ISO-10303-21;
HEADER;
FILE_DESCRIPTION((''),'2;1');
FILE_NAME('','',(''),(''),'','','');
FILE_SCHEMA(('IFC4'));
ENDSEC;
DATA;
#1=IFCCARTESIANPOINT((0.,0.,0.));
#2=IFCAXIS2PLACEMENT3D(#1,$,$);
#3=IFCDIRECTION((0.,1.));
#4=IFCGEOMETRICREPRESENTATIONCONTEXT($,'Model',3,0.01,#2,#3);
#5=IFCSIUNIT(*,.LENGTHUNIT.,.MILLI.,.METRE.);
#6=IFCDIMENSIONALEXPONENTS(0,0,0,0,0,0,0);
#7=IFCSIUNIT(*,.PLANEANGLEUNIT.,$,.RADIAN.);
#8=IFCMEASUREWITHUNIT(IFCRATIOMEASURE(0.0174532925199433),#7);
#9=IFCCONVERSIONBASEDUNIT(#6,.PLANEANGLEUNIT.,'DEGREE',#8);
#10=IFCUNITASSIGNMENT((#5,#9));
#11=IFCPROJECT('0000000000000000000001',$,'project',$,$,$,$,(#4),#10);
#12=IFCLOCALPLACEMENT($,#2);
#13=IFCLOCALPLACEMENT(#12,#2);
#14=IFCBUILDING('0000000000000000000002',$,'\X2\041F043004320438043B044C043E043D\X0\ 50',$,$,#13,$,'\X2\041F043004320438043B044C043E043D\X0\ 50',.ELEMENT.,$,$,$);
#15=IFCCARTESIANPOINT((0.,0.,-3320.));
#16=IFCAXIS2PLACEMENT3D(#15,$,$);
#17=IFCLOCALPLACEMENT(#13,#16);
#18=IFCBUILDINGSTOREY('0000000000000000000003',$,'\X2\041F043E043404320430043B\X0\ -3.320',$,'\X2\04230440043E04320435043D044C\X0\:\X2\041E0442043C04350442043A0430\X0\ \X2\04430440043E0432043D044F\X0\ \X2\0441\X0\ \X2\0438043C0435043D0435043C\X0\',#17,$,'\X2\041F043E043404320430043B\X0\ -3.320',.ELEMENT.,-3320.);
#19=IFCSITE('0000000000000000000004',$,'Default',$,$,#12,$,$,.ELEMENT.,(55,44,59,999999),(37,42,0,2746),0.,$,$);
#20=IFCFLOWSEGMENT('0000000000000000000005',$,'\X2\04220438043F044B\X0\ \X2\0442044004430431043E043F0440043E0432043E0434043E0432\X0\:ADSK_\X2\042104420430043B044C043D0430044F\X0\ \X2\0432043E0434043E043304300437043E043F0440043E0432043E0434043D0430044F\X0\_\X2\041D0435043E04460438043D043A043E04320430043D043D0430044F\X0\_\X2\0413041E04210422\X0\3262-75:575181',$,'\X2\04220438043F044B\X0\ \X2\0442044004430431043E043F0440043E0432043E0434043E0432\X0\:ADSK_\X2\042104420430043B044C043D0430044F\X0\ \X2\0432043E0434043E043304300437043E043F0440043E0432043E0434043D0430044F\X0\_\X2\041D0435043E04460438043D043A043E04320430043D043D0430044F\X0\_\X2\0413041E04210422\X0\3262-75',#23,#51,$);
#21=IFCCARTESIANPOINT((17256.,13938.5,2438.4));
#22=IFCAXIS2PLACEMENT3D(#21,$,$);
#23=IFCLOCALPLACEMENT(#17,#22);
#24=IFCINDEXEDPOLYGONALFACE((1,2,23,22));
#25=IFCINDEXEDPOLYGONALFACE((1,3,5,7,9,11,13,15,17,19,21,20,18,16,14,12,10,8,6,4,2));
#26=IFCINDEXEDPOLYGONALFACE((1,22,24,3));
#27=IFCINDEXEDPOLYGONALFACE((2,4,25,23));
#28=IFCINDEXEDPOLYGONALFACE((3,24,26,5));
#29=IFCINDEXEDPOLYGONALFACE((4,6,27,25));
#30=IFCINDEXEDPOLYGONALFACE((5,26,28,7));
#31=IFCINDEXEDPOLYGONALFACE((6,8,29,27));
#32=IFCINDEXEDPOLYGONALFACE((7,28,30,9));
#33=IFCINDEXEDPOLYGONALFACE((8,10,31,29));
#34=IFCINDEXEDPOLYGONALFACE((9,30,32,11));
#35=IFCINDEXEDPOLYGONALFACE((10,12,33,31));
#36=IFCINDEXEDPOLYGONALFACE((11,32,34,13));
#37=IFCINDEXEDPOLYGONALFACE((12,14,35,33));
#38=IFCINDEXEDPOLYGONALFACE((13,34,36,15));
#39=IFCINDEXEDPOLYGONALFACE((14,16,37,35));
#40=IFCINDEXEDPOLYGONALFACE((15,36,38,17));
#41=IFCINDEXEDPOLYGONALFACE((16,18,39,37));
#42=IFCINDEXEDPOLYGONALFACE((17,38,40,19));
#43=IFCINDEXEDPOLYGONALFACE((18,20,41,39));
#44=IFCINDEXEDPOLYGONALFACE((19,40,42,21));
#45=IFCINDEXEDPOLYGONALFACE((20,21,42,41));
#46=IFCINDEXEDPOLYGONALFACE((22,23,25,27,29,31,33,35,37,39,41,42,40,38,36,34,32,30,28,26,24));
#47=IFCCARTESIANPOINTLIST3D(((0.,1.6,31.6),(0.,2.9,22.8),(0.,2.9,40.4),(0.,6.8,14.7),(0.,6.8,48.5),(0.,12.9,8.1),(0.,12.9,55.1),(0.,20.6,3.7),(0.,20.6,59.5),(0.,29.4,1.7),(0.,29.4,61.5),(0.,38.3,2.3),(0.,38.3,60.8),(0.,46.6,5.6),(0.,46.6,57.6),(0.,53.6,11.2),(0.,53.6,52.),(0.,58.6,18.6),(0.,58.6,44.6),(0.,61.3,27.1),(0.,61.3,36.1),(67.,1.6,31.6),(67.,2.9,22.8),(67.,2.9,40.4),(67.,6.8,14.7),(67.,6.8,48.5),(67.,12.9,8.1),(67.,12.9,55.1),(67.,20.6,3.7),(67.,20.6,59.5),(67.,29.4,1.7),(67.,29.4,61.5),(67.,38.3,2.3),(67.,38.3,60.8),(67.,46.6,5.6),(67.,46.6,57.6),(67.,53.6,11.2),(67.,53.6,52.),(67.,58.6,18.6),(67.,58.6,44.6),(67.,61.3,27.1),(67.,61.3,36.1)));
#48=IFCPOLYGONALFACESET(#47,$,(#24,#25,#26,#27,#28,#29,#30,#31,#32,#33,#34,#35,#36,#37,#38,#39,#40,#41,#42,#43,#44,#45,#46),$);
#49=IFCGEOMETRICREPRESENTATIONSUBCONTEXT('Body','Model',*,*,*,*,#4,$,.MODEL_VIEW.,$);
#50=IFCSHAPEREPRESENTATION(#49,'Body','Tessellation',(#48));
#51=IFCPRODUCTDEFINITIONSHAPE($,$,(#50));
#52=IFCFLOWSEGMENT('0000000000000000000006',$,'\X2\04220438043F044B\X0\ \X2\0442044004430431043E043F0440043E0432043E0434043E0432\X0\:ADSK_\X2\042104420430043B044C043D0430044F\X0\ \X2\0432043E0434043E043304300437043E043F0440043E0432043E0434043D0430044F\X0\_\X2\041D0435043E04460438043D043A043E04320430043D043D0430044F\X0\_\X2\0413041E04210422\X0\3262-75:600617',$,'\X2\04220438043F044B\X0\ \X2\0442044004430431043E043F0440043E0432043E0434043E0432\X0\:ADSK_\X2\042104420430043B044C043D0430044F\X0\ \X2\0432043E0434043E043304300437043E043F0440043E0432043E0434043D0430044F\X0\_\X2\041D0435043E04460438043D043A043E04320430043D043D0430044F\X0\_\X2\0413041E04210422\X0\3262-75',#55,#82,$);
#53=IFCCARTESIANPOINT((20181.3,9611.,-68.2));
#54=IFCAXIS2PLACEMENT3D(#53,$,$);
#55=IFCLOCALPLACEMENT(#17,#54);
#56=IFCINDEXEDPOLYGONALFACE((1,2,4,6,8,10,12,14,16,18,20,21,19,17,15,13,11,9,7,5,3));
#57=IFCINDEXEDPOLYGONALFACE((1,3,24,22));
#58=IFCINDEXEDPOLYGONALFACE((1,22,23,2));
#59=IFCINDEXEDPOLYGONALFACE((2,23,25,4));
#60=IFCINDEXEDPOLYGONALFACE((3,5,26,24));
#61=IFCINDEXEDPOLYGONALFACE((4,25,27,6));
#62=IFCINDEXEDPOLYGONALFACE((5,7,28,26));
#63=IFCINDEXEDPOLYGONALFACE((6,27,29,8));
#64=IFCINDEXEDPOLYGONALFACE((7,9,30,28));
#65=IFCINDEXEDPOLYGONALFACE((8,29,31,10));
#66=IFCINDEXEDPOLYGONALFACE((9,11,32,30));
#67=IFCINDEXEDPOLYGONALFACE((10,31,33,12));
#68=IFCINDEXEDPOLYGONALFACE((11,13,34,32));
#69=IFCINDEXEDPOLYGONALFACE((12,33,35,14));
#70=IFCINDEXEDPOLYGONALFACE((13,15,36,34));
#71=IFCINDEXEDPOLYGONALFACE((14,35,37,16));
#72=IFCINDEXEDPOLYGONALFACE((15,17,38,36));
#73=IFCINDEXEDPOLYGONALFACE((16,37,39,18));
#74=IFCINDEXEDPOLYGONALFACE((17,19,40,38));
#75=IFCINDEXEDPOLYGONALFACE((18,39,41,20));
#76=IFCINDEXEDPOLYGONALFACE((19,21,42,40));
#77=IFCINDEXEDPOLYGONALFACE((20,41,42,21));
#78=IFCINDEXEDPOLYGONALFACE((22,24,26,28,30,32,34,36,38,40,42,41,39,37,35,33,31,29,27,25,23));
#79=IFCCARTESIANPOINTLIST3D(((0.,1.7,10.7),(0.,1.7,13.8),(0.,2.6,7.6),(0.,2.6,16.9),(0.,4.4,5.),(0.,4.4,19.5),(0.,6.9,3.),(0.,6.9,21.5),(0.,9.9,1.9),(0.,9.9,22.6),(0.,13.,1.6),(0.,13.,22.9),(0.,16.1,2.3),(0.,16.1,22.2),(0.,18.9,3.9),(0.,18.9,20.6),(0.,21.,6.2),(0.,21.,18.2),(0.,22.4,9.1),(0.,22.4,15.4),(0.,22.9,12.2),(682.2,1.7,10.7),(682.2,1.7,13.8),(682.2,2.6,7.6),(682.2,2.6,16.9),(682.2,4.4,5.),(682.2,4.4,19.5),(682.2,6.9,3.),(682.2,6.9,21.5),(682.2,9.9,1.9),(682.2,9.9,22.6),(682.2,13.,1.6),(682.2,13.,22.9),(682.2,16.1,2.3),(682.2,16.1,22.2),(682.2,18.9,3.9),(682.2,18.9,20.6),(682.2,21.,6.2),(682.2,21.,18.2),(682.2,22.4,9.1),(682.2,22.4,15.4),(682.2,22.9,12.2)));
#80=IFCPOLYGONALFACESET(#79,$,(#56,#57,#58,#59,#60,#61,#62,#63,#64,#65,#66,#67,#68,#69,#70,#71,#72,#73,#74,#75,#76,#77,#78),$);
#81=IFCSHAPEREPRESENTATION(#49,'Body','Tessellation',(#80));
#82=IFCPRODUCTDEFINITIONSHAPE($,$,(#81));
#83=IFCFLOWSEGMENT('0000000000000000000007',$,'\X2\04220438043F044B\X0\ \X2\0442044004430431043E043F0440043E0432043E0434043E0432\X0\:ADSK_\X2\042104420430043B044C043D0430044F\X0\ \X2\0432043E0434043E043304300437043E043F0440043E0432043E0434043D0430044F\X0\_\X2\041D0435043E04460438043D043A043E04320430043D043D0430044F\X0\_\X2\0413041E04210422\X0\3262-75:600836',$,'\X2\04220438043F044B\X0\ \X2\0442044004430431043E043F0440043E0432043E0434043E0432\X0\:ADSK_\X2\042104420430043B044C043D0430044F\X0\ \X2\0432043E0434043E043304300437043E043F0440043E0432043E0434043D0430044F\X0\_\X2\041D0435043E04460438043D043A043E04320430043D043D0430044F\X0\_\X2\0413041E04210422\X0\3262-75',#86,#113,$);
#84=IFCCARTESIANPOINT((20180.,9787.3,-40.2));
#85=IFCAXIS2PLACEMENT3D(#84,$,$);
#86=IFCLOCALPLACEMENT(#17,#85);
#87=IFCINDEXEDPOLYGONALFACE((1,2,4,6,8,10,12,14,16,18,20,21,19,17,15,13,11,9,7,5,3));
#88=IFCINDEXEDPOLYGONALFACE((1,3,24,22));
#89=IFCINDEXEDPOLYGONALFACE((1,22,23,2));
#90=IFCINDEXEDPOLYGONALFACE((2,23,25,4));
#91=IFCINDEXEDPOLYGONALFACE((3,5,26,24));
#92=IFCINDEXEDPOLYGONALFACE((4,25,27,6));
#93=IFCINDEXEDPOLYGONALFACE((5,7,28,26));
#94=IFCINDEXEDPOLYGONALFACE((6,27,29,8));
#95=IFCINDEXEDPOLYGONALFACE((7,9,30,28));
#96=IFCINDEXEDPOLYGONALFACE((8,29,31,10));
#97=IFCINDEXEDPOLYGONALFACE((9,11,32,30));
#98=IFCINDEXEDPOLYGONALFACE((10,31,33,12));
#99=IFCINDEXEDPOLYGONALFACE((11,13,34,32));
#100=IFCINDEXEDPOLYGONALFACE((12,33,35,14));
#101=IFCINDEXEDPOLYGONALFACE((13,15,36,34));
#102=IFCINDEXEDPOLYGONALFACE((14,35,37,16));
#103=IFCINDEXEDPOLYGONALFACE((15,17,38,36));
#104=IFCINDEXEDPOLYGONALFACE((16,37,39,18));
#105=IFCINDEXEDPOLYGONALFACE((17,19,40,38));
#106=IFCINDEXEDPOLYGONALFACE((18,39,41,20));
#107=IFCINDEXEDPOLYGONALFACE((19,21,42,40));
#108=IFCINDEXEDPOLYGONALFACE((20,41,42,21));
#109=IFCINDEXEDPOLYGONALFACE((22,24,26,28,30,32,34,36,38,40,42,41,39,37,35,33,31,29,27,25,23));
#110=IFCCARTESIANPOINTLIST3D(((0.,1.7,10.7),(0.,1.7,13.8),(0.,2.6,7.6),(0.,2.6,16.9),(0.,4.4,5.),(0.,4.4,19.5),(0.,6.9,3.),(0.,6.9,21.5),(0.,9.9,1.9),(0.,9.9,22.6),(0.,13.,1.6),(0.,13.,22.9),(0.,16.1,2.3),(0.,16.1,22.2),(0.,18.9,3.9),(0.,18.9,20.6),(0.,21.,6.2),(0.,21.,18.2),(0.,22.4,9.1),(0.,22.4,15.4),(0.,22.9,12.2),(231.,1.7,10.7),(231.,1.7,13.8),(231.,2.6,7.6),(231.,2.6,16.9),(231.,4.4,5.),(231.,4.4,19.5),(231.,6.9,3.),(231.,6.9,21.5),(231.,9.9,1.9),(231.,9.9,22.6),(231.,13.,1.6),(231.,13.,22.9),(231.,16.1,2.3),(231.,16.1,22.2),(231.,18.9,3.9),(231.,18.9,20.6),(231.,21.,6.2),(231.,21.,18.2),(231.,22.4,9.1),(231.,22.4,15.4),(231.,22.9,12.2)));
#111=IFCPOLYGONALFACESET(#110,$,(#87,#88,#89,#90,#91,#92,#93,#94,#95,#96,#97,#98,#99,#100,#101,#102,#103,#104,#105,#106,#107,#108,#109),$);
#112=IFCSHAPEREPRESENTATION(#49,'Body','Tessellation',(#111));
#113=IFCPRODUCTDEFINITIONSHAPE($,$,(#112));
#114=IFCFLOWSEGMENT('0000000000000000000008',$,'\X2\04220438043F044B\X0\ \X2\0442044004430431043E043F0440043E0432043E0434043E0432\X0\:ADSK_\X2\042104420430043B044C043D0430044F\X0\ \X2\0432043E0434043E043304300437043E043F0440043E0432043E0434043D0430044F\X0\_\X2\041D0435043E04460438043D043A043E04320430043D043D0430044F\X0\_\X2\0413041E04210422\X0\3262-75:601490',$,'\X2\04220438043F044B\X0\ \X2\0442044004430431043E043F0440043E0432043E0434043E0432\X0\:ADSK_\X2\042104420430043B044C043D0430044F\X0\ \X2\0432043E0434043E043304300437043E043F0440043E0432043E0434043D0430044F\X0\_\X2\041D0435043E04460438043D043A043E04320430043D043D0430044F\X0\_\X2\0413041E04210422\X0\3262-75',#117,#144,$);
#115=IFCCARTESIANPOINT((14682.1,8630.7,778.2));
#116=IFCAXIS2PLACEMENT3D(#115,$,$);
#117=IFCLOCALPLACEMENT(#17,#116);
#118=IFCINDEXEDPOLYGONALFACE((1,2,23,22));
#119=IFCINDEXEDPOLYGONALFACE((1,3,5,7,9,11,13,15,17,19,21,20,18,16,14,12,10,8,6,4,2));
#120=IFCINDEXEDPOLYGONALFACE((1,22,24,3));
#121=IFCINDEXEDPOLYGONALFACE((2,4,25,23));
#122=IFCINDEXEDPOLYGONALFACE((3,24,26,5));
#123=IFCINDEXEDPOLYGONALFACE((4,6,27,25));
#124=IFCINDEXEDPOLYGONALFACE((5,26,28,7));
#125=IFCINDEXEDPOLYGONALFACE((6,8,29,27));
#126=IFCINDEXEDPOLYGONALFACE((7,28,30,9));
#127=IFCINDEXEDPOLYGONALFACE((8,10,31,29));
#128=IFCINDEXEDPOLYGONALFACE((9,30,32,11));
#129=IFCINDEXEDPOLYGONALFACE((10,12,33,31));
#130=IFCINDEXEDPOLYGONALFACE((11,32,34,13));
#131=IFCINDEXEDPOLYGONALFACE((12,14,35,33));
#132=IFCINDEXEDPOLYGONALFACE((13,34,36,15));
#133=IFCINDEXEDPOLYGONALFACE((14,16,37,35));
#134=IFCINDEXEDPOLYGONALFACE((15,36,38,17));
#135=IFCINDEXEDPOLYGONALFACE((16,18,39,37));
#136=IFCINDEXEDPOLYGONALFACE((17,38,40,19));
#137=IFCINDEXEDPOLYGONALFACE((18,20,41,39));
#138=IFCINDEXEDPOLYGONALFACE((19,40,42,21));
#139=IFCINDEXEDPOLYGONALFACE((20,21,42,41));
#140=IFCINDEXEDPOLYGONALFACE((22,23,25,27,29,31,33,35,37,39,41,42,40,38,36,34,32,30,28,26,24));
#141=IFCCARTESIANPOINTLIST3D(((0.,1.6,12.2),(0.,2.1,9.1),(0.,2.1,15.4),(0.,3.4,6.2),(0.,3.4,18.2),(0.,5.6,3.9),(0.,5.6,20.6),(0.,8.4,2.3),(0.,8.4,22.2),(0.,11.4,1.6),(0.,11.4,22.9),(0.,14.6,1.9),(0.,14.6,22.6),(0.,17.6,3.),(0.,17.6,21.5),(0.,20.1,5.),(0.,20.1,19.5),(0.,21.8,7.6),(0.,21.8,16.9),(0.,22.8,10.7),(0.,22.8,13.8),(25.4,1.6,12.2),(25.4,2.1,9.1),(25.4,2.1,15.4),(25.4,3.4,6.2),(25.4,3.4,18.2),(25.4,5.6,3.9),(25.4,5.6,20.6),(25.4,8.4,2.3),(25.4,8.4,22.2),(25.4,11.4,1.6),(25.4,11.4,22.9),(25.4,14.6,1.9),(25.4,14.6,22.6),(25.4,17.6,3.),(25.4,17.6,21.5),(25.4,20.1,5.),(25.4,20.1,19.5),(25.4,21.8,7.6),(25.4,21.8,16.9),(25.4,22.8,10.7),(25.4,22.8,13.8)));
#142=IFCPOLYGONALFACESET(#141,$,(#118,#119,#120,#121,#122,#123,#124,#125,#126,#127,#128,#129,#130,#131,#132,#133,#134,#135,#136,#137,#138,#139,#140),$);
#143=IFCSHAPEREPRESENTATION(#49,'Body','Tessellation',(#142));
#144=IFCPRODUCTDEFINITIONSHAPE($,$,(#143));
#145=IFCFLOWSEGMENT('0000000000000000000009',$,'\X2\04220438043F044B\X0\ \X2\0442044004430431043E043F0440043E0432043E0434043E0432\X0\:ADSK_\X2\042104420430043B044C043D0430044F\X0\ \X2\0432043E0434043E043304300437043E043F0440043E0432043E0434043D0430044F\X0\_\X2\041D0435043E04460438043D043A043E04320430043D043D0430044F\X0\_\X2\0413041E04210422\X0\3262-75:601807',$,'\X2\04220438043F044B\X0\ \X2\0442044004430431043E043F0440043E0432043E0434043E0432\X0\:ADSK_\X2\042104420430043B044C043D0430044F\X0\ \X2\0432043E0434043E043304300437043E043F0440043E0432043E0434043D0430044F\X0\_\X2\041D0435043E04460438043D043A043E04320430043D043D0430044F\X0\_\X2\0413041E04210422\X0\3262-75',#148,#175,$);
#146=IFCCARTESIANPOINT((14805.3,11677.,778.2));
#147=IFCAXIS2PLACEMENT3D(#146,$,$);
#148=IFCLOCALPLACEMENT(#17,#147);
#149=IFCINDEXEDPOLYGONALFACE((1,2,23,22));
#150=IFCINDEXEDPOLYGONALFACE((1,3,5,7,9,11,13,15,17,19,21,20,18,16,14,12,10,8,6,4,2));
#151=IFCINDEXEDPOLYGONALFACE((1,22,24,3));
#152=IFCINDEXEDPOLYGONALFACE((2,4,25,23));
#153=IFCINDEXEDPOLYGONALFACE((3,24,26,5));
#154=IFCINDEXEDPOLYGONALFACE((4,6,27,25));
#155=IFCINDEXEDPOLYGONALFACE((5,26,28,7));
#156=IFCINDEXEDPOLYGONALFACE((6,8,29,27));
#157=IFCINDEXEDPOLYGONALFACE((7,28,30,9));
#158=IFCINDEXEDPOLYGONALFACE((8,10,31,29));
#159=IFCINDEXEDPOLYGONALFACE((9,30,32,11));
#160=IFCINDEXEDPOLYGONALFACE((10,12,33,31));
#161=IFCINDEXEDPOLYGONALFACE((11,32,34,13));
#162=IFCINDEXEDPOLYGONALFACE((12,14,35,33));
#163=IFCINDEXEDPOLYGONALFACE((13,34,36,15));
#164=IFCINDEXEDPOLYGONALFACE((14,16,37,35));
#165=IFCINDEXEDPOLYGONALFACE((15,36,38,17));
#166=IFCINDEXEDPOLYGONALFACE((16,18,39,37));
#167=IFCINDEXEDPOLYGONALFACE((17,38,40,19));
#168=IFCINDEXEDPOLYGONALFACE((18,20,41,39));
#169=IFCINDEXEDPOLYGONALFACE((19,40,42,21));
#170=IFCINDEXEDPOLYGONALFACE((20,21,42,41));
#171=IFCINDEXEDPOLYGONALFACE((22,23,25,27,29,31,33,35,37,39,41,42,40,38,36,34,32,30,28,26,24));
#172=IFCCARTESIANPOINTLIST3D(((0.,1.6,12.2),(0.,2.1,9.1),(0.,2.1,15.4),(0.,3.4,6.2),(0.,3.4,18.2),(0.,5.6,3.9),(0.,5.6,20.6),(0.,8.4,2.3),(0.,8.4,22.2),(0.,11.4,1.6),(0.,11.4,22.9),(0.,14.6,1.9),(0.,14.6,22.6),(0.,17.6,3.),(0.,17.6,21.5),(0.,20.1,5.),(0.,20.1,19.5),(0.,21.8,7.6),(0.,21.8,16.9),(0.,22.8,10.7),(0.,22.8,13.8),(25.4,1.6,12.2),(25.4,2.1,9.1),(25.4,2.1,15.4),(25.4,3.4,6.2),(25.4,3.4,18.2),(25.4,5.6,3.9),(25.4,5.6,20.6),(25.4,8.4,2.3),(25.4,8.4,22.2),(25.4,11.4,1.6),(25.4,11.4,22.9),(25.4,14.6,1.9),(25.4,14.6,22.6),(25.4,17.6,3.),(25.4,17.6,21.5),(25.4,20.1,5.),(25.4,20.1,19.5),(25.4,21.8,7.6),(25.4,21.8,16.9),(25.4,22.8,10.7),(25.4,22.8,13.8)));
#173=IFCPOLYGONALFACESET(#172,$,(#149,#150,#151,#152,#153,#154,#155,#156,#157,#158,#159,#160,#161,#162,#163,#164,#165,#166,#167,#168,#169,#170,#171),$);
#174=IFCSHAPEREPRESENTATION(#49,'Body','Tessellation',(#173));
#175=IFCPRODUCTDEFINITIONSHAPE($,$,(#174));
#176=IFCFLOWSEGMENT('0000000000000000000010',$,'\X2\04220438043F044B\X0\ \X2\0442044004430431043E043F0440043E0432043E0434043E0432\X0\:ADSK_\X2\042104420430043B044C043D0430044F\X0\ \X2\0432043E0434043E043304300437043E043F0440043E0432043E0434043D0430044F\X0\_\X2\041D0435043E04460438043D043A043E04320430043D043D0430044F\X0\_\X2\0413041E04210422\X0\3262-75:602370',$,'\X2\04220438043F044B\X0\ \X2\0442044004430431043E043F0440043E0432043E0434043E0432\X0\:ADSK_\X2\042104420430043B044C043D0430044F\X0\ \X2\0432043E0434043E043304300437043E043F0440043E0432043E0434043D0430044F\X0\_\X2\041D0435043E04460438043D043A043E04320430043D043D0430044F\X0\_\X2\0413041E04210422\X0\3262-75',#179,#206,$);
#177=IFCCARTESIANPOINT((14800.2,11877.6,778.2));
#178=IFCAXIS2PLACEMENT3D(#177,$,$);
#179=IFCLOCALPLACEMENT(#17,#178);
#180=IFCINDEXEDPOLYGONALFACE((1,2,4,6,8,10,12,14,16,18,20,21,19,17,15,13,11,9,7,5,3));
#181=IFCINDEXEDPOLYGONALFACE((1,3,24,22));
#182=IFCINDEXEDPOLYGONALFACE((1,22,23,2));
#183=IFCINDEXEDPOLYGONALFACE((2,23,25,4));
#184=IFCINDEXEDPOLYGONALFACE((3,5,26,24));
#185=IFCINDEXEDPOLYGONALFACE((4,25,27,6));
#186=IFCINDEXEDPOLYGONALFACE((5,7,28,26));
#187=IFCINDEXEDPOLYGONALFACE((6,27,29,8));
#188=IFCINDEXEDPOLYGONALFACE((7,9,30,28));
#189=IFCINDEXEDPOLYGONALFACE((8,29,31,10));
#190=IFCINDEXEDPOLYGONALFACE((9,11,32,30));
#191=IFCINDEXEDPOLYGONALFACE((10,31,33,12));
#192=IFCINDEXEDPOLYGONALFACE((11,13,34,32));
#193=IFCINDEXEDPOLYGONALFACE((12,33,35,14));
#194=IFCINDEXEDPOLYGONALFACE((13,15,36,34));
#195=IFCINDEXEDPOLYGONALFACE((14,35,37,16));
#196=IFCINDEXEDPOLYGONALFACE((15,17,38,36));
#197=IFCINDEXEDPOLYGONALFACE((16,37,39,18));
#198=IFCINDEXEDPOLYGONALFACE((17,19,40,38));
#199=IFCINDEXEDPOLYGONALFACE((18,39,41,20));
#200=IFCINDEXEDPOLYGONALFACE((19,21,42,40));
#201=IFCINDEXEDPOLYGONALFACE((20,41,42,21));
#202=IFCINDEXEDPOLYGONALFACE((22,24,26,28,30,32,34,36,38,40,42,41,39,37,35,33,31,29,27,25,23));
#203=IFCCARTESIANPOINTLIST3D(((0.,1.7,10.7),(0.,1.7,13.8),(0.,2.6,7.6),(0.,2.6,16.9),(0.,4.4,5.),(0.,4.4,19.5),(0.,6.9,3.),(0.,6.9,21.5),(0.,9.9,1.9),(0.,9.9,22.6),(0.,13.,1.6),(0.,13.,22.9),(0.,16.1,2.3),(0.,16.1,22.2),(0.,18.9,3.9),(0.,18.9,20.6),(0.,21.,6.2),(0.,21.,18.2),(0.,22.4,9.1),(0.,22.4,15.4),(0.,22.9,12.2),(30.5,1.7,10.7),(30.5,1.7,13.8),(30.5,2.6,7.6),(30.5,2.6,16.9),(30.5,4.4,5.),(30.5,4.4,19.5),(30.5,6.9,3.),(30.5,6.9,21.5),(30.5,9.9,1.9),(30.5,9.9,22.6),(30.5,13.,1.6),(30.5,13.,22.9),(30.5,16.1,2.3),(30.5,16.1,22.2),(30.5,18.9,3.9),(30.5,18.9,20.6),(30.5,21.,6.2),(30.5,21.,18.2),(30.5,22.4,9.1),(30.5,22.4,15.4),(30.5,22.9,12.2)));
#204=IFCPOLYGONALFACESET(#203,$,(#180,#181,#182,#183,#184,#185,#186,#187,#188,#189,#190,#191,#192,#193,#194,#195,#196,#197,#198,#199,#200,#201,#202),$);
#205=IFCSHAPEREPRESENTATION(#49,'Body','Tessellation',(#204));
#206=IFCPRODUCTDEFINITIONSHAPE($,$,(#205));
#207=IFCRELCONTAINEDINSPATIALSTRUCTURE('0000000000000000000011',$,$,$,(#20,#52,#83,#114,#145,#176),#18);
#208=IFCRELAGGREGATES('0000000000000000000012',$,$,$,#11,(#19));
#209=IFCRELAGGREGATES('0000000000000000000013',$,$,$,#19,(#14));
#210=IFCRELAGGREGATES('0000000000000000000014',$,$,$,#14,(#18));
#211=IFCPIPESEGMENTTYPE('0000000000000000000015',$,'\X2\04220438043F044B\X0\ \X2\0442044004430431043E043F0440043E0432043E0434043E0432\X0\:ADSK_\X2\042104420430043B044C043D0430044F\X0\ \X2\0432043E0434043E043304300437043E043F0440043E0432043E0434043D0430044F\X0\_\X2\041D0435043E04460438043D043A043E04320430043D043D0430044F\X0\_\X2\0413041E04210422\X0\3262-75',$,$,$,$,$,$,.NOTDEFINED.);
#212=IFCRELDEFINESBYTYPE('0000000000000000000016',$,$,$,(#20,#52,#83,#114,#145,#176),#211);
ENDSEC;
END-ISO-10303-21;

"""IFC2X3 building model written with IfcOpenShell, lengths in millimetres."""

from ifc_helpers import new_model, entity, si_unit, converted_unit, direction, frame, frame_2d, origin, origin_2d_with_axis, place, context, subcontext, project, spatial, circle, extrude, type_object, element, save


model = new_model("IFC2X3")

# Units and contexts
model_context = context("Model", 3, precision=0.01, world=origin(), true_north=direction((0.0, 1.0)))
body_context = subcontext(model_context, "Body", "Model", "MODEL_VIEW")
ifc_project = project(units=[si_unit("LENGTHUNIT", "METRE", prefix="MILLI"), converted_unit("PLANEANGLEUNIT", "DEGREE", entity("IfcRatioMeasure", 0.0174532925199433), si_unit("PLANEANGLEUNIT", "RADIAN"), dimensions=[0, 0, 0, 0, 0, 0, 0])], contexts=[model_context])

# Site, building, storey
site_placement = place(None, origin())
site = spatial("IfcSite", under=ifc_project, at=site_placement, Name="Default", CompositionType="ELEMENT", RefLatitude=(55, 44, 59, 999999), RefLongitude=(37, 42, 0, 2746), RefElevation=0.0)
building_placement = place(site_placement, origin())
building = spatial("IfcBuilding", under=site, at=building_placement, Name="Павильон 50", LongName="Павильон 50", CompositionType="ELEMENT")
storey_placement = place(building_placement, frame((0.0, 0.0, -3320.0)))
storey = spatial("IfcBuildingStorey", under=building, at=storey_placement, Name="Подвал -3.320", ObjectType="Уровень:Отметка уровня с именем", LongName="Подвал -3.320", CompositionType="ELEMENT", Elevation=-3320.0)

# Flow segments
pipe_segment_type = type_object("IfcPipeSegmentType", Name="Типы трубопроводов:ADSK_Стальная водогазопроводная_Неоцинкованная_ГОСТ3262-75", PredefinedType="NOTDEFINED")
flow_segment_1_placement = place(storey_placement, frame((17256.0, 13938.5, 2438.4)))
element("IfcFlowSegment", 1, at=flow_segment_1_placement, inside=storey, type_object=pipe_segment_type, Name="Типы трубопроводов:ADSK_Стальная водогазопроводная_Неоцинкованная_ГОСТ3262-75:575181", ObjectType="Типы трубопроводов:ADSK_Стальная водогазопроводная_Неоцинкованная_ГОСТ3262-75", context=body_context, shape_type="SweptSolid", body=[
    extrude(circle(Radius=30.0, at=origin_2d_with_axis()), frame((0.0, 31.6, 31.6), z_axis=(1.0, 0.0, 0.0), x_axis=(0.0, -1.0, 0.0)), (0.0, 0.0, 1.0), 67.0),
])
flow_segment_2_placement = place(storey_placement, frame((20181.3, 9611.0, -68.2)))
element("IfcFlowSegment", 2, at=flow_segment_2_placement, inside=storey, type_object=pipe_segment_type, Name="Типы трубопроводов:ADSK_Стальная водогазопроводная_Неоцинкованная_ГОСТ3262-75:600617", ObjectType="Типы трубопроводов:ADSK_Стальная водогазопроводная_Неоцинкованная_ГОСТ3262-75", context=body_context, shape_type="SweptSolid", body=[
    extrude(circle(Radius=10.7, at=origin_2d_with_axis()), frame((0.0, 12.2, 12.2), z_axis=(1.0, 0.0, 0.0), x_axis=(0.0, 1.0, 0.0)), (0.0, 0.0, 1.0), 682.2),
])
flow_segment_3_placement = place(storey_placement, frame((20180.0, 9787.3, -40.2)))
element("IfcFlowSegment", 3, at=flow_segment_3_placement, inside=storey, type_object=pipe_segment_type, Name="Типы трубопроводов:ADSK_Стальная водогазопроводная_Неоцинкованная_ГОСТ3262-75:600836", ObjectType="Типы трубопроводов:ADSK_Стальная водогазопроводная_Неоцинкованная_ГОСТ3262-75", context=body_context, shape_type="SweptSolid", body=[
    extrude(circle(Radius=10.7, at=origin_2d_with_axis()), frame((0.0, 12.2, 12.2), z_axis=(1.0, 0.0, 0.0), x_axis=(0.0, 1.0, 0.0)), (0.0, 0.0, 1.0), 231.0),
])
flow_segment_4_placement = place(storey_placement, frame((14682.1, 8630.7, 778.2)))
element("IfcFlowSegment", 4, at=flow_segment_4_placement, inside=storey, type_object=pipe_segment_type, Name="Типы трубопроводов:ADSK_Стальная водогазопроводная_Неоцинкованная_ГОСТ3262-75:601490", ObjectType="Типы трубопроводов:ADSK_Стальная водогазопроводная_Неоцинкованная_ГОСТ3262-75", context=body_context, shape_type="SweptSolid", body=[
    extrude(circle(Radius=10.7, at=origin_2d_with_axis()), frame((0.0, 12.2, 12.2), z_axis=(1.0, 0.0, 0.0), x_axis=(0.0, -1.0, 0.0)), (0.0, 0.0, 1.0), 25.4),
])
flow_segment_5_placement = place(storey_placement, frame((14805.3, 11677.0, 778.2)))
element("IfcFlowSegment", 5, at=flow_segment_5_placement, inside=storey, type_object=pipe_segment_type, Name="Типы трубопроводов:ADSK_Стальная водогазопроводная_Неоцинкованная_ГОСТ3262-75:601807", ObjectType="Типы трубопроводов:ADSK_Стальная водогазопроводная_Неоцинкованная_ГОСТ3262-75", context=body_context, shape_type="SweptSolid", body=[
    extrude(circle(Radius=10.7, at=origin_2d_with_axis()), frame((0.0, 12.2, 12.2), z_axis=(1.0, 0.0, 0.0), x_axis=(0.0, -1.0, 0.0)), (0.0, 0.0, 1.0), 25.4),
])
flow_segment_6_placement = place(storey_placement, frame((14800.2, 11877.6, 778.2)))
element("IfcFlowSegment", 6, at=flow_segment_6_placement, inside=storey, type_object=pipe_segment_type, Name="Типы трубопроводов:ADSK_Стальная водогазопроводная_Неоцинкованная_ГОСТ3262-75:602370", ObjectType="Типы трубопроводов:ADSK_Стальная водогазопроводная_Неоцинкованная_ГОСТ3262-75", context=body_context, shape_type="SweptSolid", body=[
    extrude(circle(Radius=10.7, at=frame_2d((0.0, 0.0), x_axis=(1.0, 0.0))), frame((0.0, 12.2, 12.2), z_axis=(1.0, 0.0, 0.0), x_axis=(0.0, 1.0, 0.0)), (0.0, 0.0, 1.0), 30.5),
])

save(model, "model.ifc")
